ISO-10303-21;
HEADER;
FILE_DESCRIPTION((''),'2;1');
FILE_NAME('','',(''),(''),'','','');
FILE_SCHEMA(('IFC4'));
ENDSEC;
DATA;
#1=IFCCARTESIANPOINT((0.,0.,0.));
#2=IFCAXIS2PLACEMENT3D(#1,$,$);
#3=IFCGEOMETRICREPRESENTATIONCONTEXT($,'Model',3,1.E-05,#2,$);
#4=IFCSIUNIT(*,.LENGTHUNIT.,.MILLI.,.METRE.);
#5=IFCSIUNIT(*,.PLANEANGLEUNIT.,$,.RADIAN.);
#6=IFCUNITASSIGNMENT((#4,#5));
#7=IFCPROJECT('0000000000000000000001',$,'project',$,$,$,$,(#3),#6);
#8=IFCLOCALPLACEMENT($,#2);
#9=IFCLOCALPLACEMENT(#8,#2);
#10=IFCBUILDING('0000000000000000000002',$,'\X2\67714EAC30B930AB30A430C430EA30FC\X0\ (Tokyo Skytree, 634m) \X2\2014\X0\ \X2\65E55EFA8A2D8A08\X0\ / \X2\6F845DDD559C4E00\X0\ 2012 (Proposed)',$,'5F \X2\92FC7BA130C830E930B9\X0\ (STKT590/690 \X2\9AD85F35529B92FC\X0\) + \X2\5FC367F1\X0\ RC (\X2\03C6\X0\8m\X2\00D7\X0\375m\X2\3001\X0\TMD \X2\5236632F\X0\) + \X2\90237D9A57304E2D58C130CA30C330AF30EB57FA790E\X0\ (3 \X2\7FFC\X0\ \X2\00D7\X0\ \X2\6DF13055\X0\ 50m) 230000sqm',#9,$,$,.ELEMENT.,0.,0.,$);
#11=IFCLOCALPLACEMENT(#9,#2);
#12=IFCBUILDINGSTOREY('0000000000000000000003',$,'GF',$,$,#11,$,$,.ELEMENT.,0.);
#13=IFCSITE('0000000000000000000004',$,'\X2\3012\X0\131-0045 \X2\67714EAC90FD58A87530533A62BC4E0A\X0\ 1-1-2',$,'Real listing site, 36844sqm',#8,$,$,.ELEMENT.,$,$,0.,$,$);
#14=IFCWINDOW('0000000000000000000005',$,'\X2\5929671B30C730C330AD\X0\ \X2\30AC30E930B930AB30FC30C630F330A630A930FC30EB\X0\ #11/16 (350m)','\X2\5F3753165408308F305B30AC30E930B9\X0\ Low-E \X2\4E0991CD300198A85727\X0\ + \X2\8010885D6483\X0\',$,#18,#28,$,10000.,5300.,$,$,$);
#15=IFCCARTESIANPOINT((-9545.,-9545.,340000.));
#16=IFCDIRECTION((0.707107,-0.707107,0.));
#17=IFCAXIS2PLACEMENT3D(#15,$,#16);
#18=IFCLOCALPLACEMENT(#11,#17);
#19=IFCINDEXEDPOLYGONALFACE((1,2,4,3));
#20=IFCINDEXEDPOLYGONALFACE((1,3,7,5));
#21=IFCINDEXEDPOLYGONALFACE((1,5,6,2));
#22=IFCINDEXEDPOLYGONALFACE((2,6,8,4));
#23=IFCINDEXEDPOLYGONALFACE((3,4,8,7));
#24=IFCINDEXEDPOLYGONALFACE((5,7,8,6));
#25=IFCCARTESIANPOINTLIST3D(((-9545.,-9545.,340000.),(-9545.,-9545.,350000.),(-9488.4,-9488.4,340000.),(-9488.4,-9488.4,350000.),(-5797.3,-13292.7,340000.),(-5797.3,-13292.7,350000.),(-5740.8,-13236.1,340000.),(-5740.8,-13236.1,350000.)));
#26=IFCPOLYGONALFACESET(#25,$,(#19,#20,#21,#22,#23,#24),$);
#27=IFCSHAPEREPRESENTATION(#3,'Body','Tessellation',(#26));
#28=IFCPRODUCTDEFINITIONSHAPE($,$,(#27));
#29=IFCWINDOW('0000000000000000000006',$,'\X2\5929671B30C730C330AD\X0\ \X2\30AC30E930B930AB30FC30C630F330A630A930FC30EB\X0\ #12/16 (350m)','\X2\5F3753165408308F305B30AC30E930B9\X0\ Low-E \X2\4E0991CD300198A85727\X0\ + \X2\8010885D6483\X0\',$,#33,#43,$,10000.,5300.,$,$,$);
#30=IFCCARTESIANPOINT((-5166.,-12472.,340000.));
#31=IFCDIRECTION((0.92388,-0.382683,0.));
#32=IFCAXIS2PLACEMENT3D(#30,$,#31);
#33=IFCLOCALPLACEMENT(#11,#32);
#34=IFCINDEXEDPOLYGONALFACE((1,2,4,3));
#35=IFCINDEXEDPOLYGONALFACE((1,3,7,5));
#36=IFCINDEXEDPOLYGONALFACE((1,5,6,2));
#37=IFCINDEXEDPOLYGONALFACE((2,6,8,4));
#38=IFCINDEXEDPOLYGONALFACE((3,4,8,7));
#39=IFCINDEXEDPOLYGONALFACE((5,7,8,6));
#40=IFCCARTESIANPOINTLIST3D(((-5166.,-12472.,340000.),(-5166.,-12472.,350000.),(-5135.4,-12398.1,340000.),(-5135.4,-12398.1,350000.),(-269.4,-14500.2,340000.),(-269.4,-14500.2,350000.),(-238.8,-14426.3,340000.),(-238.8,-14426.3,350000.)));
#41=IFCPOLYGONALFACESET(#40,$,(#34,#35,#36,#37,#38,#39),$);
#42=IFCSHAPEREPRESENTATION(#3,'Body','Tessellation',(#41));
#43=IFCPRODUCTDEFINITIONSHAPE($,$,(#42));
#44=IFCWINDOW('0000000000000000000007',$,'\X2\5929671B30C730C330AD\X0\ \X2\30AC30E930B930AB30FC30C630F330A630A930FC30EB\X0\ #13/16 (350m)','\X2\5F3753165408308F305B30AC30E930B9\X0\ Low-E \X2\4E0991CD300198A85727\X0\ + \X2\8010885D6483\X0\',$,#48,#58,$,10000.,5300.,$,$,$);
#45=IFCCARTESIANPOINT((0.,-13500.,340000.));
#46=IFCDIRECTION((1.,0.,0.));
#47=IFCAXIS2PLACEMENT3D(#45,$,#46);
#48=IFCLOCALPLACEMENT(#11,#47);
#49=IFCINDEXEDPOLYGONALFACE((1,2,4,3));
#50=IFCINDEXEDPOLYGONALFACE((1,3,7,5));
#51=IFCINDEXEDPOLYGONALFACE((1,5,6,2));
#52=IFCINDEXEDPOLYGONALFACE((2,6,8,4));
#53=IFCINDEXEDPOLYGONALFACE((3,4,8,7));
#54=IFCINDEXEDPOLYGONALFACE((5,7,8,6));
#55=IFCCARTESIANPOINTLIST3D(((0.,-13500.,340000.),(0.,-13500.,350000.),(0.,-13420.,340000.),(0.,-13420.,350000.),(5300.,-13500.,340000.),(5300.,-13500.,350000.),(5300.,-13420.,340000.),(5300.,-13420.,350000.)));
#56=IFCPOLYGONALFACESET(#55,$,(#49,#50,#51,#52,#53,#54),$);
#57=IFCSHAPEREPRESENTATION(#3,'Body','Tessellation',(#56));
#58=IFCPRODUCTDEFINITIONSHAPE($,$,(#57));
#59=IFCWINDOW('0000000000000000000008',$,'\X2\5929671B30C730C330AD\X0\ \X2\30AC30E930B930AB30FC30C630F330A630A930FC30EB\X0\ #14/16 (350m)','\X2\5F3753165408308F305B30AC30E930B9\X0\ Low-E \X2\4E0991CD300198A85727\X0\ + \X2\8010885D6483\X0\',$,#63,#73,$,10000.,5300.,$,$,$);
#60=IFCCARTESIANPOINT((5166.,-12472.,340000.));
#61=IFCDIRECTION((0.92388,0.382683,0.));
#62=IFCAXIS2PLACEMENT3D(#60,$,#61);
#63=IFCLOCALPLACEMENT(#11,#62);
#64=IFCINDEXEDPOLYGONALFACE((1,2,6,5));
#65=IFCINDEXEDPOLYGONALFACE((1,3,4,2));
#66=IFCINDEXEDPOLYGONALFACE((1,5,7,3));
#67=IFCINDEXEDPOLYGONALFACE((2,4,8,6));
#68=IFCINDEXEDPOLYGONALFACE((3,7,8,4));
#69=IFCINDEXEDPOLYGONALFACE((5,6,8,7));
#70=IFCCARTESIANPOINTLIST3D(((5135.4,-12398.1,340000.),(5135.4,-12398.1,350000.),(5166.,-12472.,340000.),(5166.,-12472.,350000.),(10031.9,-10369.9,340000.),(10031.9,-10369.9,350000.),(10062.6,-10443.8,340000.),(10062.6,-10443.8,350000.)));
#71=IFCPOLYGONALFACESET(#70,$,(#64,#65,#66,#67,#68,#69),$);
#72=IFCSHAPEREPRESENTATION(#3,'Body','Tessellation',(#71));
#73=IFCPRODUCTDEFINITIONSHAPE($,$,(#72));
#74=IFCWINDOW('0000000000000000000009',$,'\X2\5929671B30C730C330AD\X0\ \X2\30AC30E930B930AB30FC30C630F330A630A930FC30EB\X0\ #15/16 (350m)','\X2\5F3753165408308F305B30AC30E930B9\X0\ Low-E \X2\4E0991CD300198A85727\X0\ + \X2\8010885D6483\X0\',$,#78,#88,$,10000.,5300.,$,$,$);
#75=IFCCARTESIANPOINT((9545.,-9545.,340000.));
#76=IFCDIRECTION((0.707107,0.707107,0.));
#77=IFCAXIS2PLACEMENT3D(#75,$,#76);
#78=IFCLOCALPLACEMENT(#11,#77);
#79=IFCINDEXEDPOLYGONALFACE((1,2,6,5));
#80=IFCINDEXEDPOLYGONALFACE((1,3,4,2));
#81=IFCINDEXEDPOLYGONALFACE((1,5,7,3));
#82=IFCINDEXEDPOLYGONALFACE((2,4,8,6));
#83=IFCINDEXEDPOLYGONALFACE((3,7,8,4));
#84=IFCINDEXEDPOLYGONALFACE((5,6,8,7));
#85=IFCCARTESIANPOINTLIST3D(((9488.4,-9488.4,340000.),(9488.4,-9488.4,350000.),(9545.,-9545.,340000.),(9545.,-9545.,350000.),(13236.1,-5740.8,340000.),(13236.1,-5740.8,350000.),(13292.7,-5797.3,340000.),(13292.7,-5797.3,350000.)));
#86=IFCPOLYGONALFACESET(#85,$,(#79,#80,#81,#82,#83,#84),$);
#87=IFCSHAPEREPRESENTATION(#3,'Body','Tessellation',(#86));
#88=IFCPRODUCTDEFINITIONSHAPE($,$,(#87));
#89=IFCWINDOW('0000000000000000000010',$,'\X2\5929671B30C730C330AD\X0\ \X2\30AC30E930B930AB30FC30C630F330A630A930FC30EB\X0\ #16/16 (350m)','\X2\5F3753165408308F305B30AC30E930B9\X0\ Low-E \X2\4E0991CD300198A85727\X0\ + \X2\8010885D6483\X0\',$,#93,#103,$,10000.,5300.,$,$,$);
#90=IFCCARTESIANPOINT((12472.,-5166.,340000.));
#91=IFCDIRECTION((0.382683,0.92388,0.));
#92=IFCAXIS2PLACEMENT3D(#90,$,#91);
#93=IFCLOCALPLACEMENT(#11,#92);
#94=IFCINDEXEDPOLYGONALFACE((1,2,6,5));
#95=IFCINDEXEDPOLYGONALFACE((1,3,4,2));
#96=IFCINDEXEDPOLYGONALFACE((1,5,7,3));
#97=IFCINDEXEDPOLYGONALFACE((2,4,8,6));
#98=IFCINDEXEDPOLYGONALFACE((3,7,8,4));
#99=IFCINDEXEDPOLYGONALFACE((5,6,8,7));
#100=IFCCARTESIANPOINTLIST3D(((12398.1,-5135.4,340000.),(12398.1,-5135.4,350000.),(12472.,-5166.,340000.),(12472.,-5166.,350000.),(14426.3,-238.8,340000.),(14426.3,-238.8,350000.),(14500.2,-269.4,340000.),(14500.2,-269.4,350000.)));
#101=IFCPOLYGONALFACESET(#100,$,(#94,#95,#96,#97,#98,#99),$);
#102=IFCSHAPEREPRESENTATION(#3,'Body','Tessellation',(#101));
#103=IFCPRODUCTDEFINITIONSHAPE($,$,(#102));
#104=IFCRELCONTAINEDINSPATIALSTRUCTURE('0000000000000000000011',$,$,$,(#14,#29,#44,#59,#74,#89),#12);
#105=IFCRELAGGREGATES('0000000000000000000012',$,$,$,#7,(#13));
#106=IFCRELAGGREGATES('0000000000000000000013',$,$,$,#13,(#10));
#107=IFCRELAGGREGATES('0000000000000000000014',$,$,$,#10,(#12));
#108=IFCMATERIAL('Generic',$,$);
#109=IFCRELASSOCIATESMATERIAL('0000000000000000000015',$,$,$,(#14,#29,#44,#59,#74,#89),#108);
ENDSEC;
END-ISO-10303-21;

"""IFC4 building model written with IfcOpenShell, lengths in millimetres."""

from ifc_helpers import new_model, si_unit, frame, frame_2d, origin, place, context, project, spatial, rectangle, extrude, material, element, save


model = new_model("IFC4")

# Units and contexts
model_context = context("Model", 3, precision=1e-05, world=origin())
ifc_project = project(units=[si_unit("LENGTHUNIT", "METRE", prefix="MILLI"), si_unit("PLANEANGLEUNIT", "RADIAN")], contexts=[model_context])

# Site, building, storey
site_placement = place(None, origin())
site = spatial("IfcSite", under=ifc_project, at=site_placement, Name="〒131-0045 東京都墨田区押上 1-1-2", ObjectType="Real listing site, 36844sqm", CompositionType="ELEMENT", RefElevation=0.0)
building_placement = place(site_placement, origin())
building = spatial("IfcBuilding", under=site, at=building_placement, Name="東京スカイツリー (Tokyo Skytree, 634m) — 日建設計 / 澄川喜一 2012 (Proposed)", ObjectType="5F 鋼管トラス (STKT590/690 高張力鋼) + 心柱 RC (φ8m×375m、TMD 制振) + 連続地中壁ナックル基礎 (3 翼 × 深さ 50m) 230000sqm", CompositionType="ELEMENT", ElevationOfRefHeight=0.0, ElevationOfTerrain=0.0)
storey_placement = place(building_placement, origin())
storey = spatial("IfcBuildingStorey", under=building, at=storey_placement, Name="GF", CompositionType="ELEMENT", Elevation=0.0)

# Shared definitions
ifc_material = material(Name="Generic")

# Windows
window_1_placement = place(storey_placement, frame((-9545.0, -9545.0, 340000.0), x_axis=(0.707107, -0.707107, 0.0)))
element("IfcWindow", 1, at=window_1_placement, inside=storey, material=ifc_material, Name="天望デッキ ガラスカーテンウォール #11/16 (350m)", Description="強化合わせガラス Low-E 三重、風圧 + 耐衝撃", OverallHeight=10000.0, OverallWidth=5300.0, context=model_context, shape_type="SweptSolid", body=[
    extrude(rectangle(XDim=5300.0, YDim=80.0, at=frame_2d((2650.0, 40.0))), frame((-9545.0, -9545.0, 340000.0), x_axis=(0.707107, -0.707107, 0.0)), (0.0, 0.0, 1.0), 10000.0),
])
window_2_placement = place(storey_placement, frame((-5166.0, -12472.0, 340000.0), x_axis=(0.92388, -0.382683, 0.0)))
element("IfcWindow", 2, at=window_2_placement, inside=storey, material=ifc_material, Name="天望デッキ ガラスカーテンウォール #12/16 (350m)", Description="強化合わせガラス Low-E 三重、風圧 + 耐衝撃", OverallHeight=10000.0, OverallWidth=5300.0, context=model_context, shape_type="SweptSolid", body=[
    extrude(rectangle(XDim=5300.0, YDim=80.0, at=frame_2d((2650.0, 40.0))), frame((-5166.0, -12472.0, 340000.0), x_axis=(0.92388, -0.382683, 0.0)), (0.0, 0.0, 1.0), 10000.0),
])
window_3_placement = place(storey_placement, frame((0.0, -13500.0, 340000.0), x_axis=(1.0, 0.0, 0.0)))
element("IfcWindow", 3, at=window_3_placement, inside=storey, material=ifc_material, Name="天望デッキ ガラスカーテンウォール #13/16 (350m)", Description="強化合わせガラス Low-E 三重、風圧 + 耐衝撃", OverallHeight=10000.0, OverallWidth=5300.0, context=model_context, shape_type="SweptSolid", body=[
    extrude(rectangle(XDim=5300.0, YDim=80.0, at=frame_2d((2650.0, 40.0))), frame((0.0, -13500.0, 340000.0), x_axis=(1.0, 0.0, 0.0)), (0.0, 0.0, 1.0), 10000.0),
])
window_4_placement = place(storey_placement, frame((5166.0, -12472.0, 340000.0), x_axis=(0.92388, 0.382683, 0.0)))
element("IfcWindow", 4, at=window_4_placement, inside=storey, material=ifc_material, Name="天望デッキ ガラスカーテンウォール #14/16 (350m)", Description="強化合わせガラス Low-E 三重、風圧 + 耐衝撃", OverallHeight=10000.0, OverallWidth=5300.0, context=model_context, shape_type="SweptSolid", body=[
    extrude(rectangle(XDim=5300.0, YDim=80.0, at=frame_2d((2650.0, 40.0))), frame((5166.0, -12472.0, 340000.0), x_axis=(0.92388, 0.382683, 0.0)), (0.0, 0.0, 1.0), 10000.0),
])
window_5_placement = place(storey_placement, frame((9545.0, -9545.0, 340000.0), x_axis=(0.707107, 0.707107, 0.0)))
element("IfcWindow", 5, at=window_5_placement, inside=storey, material=ifc_material, Name="天望デッキ ガラスカーテンウォール #15/16 (350m)", Description="強化合わせガラス Low-E 三重、風圧 + 耐衝撃", OverallHeight=10000.0, OverallWidth=5300.0, context=model_context, shape_type="SweptSolid", body=[
    extrude(rectangle(XDim=5300.0, YDim=80.0, at=frame_2d((2650.0, 40.0))), frame((9545.0, -9545.0, 340000.0), x_axis=(0.707107, 0.707107, 0.0)), (0.0, 0.0, 1.0), 10000.0),
])
window_6_placement = place(storey_placement, frame((12472.0, -5166.0, 340000.0), x_axis=(0.382683, 0.92388, 0.0)))
element("IfcWindow", 6, at=window_6_placement, inside=storey, material=ifc_material, Name="天望デッキ ガラスカーテンウォール #16/16 (350m)", Description="強化合わせガラス Low-E 三重、風圧 + 耐衝撃", OverallHeight=10000.0, OverallWidth=5300.0, context=model_context, shape_type="SweptSolid", body=[
    extrude(rectangle(XDim=5300.0, YDim=80.0, at=frame_2d((2650.0, 40.0))), frame((12472.0, -5166.0, 340000.0), x_axis=(0.382683, 0.92388, 0.0)), (0.0, 0.0, 1.0), 10000.0),
])

save(model, "model.ifc")
